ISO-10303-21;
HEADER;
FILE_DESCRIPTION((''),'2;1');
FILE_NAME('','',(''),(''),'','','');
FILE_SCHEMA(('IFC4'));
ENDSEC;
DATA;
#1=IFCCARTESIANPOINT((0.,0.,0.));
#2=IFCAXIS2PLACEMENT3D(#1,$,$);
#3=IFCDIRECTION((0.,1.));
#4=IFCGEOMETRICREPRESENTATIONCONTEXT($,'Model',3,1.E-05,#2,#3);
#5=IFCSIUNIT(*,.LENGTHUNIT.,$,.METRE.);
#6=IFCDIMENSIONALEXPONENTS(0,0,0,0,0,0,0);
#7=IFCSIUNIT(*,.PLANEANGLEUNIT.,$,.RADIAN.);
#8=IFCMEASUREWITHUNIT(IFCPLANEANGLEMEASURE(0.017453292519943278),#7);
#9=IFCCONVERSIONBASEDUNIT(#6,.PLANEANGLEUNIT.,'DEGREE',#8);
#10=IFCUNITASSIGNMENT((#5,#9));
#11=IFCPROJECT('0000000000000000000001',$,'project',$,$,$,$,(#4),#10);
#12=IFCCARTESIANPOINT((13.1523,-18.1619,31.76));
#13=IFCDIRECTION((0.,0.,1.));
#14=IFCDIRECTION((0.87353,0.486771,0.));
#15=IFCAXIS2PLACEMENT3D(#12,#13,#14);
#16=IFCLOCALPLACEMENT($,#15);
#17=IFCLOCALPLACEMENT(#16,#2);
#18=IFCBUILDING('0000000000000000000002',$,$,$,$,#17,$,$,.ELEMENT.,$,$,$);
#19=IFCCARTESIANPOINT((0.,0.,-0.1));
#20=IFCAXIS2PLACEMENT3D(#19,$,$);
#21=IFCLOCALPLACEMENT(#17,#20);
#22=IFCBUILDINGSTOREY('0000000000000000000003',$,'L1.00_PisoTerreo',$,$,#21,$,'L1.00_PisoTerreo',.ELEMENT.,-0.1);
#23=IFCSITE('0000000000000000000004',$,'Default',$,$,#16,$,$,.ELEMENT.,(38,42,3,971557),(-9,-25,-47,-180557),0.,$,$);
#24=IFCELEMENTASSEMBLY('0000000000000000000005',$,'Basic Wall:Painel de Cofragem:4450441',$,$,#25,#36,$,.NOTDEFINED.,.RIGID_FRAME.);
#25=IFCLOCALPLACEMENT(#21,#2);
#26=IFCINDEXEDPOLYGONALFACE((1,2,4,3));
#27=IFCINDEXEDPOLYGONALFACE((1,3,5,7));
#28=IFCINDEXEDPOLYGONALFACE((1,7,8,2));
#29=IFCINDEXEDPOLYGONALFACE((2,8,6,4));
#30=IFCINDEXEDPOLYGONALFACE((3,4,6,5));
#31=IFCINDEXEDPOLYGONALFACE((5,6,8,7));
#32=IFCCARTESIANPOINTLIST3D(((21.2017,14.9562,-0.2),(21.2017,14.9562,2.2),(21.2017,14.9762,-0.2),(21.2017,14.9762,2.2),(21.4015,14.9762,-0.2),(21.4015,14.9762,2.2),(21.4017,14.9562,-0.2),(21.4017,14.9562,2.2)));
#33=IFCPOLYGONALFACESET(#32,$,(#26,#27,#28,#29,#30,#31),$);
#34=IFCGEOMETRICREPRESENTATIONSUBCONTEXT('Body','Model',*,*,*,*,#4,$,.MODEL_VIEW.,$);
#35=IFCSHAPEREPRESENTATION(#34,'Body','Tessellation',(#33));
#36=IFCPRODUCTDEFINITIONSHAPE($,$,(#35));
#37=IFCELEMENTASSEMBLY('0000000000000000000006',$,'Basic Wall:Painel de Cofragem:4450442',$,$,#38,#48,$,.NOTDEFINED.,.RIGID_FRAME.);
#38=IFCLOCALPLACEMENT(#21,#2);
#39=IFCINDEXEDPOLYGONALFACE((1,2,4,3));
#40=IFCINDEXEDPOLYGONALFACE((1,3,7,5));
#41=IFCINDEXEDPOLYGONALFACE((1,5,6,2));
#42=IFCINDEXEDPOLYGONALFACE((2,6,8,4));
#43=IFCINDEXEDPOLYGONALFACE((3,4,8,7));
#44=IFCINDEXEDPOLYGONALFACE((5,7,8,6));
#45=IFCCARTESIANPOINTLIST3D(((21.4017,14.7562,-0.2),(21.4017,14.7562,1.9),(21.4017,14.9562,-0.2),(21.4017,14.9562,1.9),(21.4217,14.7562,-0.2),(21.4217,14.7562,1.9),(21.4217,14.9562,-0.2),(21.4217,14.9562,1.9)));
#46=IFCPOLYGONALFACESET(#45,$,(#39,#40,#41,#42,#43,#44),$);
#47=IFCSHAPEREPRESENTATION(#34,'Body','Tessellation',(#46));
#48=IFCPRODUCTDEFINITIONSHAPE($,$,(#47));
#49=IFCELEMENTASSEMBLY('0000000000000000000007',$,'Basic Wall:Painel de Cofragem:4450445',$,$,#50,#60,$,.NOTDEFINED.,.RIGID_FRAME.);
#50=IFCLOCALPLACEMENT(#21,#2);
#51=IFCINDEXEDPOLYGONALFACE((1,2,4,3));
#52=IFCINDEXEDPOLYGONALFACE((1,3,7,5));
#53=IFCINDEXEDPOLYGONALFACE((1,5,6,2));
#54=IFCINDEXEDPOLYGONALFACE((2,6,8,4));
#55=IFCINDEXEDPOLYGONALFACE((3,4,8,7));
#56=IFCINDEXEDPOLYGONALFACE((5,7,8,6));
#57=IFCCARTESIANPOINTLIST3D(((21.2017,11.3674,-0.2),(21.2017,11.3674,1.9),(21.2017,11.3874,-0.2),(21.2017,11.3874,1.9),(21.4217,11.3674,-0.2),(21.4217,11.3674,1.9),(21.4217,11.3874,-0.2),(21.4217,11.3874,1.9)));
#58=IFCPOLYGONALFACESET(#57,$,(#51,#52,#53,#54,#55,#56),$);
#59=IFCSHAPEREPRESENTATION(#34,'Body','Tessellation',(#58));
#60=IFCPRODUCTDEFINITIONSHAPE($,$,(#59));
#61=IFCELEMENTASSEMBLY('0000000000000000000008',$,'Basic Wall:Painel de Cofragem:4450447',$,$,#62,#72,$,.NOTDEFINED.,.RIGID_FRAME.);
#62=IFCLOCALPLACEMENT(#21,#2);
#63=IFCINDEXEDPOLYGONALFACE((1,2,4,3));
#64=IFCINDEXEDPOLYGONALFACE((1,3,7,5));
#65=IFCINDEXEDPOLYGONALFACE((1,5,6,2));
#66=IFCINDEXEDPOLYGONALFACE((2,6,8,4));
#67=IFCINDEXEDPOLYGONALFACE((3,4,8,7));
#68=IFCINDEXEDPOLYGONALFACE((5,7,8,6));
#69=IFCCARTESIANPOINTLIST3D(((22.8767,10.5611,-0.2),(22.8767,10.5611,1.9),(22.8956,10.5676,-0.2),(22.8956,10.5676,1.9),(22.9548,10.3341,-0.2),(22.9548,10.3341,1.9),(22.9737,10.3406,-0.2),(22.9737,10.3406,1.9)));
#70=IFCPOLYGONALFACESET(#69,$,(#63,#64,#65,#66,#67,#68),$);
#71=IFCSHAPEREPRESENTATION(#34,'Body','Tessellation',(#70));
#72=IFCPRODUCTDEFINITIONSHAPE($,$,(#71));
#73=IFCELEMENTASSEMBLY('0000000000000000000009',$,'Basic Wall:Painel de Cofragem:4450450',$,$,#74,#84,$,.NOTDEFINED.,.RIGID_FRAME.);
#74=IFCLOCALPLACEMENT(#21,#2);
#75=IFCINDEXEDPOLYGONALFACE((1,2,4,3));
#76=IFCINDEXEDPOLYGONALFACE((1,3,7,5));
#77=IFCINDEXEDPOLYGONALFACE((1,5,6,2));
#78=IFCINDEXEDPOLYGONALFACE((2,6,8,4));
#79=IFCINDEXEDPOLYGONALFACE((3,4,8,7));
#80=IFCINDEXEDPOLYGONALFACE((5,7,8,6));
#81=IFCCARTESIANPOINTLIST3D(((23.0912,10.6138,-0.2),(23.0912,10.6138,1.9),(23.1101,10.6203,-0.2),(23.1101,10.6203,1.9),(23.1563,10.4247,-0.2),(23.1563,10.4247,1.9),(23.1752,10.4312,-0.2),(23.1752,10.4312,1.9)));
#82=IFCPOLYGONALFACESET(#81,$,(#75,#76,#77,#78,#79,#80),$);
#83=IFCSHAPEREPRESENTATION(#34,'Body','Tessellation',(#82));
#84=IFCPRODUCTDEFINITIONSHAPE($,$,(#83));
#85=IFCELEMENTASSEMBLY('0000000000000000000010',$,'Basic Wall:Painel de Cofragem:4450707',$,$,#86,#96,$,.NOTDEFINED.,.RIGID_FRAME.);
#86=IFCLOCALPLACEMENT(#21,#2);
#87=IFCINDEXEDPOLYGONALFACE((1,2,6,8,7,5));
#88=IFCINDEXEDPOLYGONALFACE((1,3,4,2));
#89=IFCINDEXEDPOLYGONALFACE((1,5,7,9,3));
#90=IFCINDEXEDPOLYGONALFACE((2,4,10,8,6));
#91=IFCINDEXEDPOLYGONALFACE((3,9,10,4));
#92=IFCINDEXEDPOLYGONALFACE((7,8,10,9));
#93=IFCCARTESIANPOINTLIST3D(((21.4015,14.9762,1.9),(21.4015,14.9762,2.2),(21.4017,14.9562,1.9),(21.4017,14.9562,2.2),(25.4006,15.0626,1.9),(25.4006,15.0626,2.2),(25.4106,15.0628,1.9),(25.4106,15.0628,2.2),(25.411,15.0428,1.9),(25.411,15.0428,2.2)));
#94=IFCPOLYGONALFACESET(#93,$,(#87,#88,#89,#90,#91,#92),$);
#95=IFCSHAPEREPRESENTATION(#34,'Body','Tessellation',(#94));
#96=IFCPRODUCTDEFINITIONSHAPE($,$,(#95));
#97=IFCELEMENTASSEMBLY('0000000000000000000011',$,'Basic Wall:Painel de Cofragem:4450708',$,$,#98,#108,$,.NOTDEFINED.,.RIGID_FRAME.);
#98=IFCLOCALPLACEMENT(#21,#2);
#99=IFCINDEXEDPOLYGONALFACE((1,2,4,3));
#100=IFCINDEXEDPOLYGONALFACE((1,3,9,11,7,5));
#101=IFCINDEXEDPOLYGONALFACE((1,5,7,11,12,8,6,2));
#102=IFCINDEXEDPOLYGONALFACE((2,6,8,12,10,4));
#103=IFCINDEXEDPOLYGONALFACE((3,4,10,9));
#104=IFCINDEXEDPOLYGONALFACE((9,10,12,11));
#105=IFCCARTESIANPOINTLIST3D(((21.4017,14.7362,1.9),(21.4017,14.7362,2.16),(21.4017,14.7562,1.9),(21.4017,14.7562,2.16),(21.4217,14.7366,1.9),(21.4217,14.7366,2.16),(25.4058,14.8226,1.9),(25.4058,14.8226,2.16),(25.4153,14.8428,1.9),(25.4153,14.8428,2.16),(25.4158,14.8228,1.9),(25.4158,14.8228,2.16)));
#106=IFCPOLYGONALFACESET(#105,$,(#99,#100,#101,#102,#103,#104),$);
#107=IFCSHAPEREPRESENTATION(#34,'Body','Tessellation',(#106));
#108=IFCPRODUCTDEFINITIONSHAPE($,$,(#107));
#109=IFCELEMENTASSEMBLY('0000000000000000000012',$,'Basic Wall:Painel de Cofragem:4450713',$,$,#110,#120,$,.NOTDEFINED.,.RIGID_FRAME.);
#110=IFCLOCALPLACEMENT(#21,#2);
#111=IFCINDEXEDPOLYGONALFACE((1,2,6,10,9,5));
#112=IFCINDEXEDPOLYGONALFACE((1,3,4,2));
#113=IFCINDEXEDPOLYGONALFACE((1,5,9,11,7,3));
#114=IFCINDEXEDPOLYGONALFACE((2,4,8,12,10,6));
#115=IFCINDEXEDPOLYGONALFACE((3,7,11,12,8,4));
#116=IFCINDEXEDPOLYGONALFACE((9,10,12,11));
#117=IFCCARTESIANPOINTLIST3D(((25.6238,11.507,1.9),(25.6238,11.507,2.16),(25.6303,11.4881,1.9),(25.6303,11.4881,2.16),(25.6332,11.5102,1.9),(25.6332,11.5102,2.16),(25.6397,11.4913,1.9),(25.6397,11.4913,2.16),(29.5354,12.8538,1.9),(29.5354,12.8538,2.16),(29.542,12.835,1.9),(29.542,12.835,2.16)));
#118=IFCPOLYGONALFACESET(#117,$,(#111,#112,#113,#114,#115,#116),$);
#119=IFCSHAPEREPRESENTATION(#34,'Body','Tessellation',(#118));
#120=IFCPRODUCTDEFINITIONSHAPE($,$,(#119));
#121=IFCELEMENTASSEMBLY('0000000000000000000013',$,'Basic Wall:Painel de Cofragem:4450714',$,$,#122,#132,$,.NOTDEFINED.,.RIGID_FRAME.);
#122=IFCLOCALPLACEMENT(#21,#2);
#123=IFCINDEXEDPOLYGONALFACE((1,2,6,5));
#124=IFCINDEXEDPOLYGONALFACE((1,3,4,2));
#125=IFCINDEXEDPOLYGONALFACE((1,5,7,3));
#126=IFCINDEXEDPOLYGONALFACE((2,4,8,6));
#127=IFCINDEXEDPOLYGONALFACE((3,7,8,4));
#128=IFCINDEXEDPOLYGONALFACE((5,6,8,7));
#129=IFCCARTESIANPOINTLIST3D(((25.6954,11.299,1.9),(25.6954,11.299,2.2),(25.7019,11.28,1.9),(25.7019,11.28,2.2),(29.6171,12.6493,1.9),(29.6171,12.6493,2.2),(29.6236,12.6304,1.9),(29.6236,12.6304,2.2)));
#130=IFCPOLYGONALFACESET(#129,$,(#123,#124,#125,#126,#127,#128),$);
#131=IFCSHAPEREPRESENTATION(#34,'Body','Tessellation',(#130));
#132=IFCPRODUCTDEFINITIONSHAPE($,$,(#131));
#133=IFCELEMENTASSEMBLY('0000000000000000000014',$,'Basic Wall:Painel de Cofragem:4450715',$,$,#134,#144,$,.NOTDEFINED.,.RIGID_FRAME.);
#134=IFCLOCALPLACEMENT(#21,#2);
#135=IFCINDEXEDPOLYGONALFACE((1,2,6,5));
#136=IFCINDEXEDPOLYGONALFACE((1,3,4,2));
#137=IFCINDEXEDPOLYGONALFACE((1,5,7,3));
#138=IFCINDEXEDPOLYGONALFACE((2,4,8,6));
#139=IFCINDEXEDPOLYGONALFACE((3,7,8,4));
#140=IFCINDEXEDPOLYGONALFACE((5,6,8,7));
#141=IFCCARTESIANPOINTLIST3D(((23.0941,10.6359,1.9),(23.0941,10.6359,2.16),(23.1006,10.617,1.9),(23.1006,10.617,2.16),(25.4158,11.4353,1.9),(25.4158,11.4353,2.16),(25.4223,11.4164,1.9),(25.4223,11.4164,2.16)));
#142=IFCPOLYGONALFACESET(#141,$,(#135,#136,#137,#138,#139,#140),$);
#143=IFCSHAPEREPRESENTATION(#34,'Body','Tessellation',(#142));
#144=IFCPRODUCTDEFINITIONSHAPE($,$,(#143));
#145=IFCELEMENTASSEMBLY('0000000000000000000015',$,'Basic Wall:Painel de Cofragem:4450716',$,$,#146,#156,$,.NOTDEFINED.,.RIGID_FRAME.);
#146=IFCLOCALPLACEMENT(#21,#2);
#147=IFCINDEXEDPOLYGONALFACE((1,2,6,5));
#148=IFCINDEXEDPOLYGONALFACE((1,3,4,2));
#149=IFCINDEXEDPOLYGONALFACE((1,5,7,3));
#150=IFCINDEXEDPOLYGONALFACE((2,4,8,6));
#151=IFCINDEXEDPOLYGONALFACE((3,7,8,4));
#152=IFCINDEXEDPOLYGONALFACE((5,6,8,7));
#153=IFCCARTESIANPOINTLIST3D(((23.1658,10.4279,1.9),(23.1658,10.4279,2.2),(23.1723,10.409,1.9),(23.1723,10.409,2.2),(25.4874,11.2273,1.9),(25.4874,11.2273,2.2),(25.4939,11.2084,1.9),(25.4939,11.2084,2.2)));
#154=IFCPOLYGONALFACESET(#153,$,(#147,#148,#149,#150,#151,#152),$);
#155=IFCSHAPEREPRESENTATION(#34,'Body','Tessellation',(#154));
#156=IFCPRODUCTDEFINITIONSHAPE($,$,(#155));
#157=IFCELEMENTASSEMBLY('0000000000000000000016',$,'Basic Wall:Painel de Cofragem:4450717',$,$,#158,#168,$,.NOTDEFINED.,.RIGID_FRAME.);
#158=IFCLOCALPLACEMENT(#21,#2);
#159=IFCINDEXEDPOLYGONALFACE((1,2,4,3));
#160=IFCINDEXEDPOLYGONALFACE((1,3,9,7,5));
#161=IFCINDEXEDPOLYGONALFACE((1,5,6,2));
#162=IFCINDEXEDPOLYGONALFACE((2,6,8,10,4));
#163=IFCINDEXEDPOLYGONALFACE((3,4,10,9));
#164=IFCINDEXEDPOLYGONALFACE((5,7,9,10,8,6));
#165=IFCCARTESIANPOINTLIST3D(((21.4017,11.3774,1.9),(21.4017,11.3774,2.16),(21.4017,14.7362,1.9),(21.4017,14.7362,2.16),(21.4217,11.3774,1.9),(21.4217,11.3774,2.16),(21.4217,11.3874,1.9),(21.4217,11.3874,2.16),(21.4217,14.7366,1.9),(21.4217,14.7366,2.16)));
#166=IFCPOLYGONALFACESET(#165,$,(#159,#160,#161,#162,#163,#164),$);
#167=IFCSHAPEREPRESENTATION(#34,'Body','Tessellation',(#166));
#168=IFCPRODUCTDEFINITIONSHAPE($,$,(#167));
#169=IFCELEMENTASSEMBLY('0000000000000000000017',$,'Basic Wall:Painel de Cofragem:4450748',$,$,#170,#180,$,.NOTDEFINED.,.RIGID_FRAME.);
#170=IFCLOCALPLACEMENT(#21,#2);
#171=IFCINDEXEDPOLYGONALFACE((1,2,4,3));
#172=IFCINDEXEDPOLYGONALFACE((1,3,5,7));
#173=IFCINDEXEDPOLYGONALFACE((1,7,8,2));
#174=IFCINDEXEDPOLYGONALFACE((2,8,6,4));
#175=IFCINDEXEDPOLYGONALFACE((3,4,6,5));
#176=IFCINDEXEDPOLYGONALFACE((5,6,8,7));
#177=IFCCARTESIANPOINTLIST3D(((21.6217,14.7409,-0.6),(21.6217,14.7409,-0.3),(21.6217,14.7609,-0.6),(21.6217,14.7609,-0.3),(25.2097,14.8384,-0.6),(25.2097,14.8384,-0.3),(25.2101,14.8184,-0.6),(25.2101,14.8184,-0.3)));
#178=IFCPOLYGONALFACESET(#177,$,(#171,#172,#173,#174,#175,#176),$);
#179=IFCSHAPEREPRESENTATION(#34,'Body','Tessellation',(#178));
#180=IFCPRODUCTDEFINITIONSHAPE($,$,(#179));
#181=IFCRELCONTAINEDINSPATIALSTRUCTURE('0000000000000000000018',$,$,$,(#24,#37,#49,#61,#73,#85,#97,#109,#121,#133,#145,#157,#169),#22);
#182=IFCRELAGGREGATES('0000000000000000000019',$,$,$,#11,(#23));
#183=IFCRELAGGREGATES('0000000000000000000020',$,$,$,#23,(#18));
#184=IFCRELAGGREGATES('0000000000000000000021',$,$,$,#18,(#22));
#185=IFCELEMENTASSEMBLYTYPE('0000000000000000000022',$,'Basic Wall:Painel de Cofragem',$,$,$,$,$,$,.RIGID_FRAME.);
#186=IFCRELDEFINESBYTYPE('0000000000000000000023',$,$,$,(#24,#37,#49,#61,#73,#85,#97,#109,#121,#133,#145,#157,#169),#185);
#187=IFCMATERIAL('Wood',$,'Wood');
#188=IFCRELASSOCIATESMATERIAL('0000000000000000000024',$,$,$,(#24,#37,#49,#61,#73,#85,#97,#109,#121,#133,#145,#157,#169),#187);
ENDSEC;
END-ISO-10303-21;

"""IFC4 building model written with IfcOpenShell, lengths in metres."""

from ifc_helpers import new_model, entity, si_unit, converted_unit, direction, frame, origin, place, context, subcontext, project, spatial, indexed_curve, outline, extrude, material, type_object, element, save


model = new_model("IFC4")

# Units and contexts
model_context = context("Model", 3, precision=1e-05, world=origin(), true_north=direction((0.0, 1.0)))
body_context = subcontext(model_context, "Body", "Model", "MODEL_VIEW")
ifc_project = project(units=[si_unit("LENGTHUNIT", "METRE"), converted_unit("PLANEANGLEUNIT", "DEGREE", entity("IfcPlaneAngleMeasure", 0.017453292519943278), si_unit("PLANEANGLEUNIT", "RADIAN"), dimensions=[0, 0, 0, 0, 0, 0, 0])], contexts=[model_context])

# Site, building, storey
site_placement = place(None, frame((13.1523, -18.1619, 31.76), z_axis=(0.0, 0.0, 1.0), x_axis=(0.87353, 0.486771, 0.0)))
site = spatial("IfcSite", under=ifc_project, at=site_placement, Name="Default", CompositionType="ELEMENT", RefLatitude=(38, 42, 3, 971557), RefLongitude=(-9, -25, -47, -180557), RefElevation=0.0)
building_placement = place(site_placement, origin())
building = spatial("IfcBuilding", under=site, at=building_placement, CompositionType="ELEMENT")
storey_placement = place(building_placement, frame((0.0, 0.0, -0.1)))
storey = spatial("IfcBuildingStorey", under=building, at=storey_placement, Name="L1.00_PisoTerreo", LongName="L1.00_PisoTerreo", CompositionType="ELEMENT", Elevation=-0.1)

# Element assemblies
ifc_material_1 = material(Name="Wood", Category="Wood")
element_assembly_type = type_object("IfcElementAssemblyType", Name="Basic Wall:Painel de Cofragem", PredefinedType="RIGID_FRAME")
assembly_1_placement = place(storey_placement, frame((21.4017, 14.9662, -0.2), z_axis=(0.0, 0.0, 1.0), x_axis=(-1.0, 0.0, 0.0)))
element("IfcElementAssembly", 1, at=assembly_1_placement, inside=storey, type_object=element_assembly_type, material=ifc_material_1, Name="Basic Wall:Painel de Cofragem:4450441", AssemblyPlace="NOTDEFINED", PredefinedType="RIGID_FRAME", context=body_context, shape_type="SweptSolid", body=[
    extrude(outline(indexed_curve([(0.2, -0.01), (0.2, 0.01), (0.0, 0.01), (0.0002, -0.01), (0.2, -0.01)], self_intersect=False)), origin(), (0.0, 0.0, 1.0), 2.4),
])
assembly_2_placement = place(storey_placement, frame((21.4117, 14.9562, -0.2), z_axis=(0.0, 0.0, 1.0), x_axis=(0.0, -1.0, 0.0)))
element("IfcElementAssembly", 2, at=assembly_2_placement, inside=storey, type_object=element_assembly_type, material=ifc_material_1, Name="Basic Wall:Painel de Cofragem:4450442", AssemblyPlace="NOTDEFINED", PredefinedType="RIGID_FRAME", context=body_context, shape_type="SweptSolid", body=[
    extrude(outline(indexed_curve([(0.2, 0.01), (0.0, 0.01), (0.0, -0.01), (0.2, -0.01), (0.2, 0.01)], self_intersect=False)), origin(), (0.0, 0.0, 1.0), 2.1),
])
assembly_3_placement = place(storey_placement, frame((21.4217, 11.3774, -0.2), z_axis=(0.0, 0.0, 1.0), x_axis=(-1.0, 0.0, 0.0)))
element("IfcElementAssembly", 3, at=assembly_3_placement, inside=storey, type_object=element_assembly_type, material=ifc_material_1, Name="Basic Wall:Painel de Cofragem:4450445", AssemblyPlace="NOTDEFINED", PredefinedType="RIGID_FRAME", context=body_context, shape_type="SweptSolid", body=[
    extrude(outline(indexed_curve([(0.22, 0.01), (0.0, 0.01), (0.0, -0.01), (0.22, -0.01), (0.22, 0.01)], self_intersect=False)), origin(), (0.0, 0.0, 1.0), 2.1),
])
assembly_4_placement = place(storey_placement, frame((22.8861, 10.5643, -0.2), z_axis=(0.0, 0.0, 1.0), x_axis=(0.325568, -0.945519, 0.0)))
element("IfcElementAssembly", 4, at=assembly_4_placement, inside=storey, type_object=element_assembly_type, material=ifc_material_1, Name="Basic Wall:Painel de Cofragem:4450447", AssemblyPlace="NOTDEFINED", PredefinedType="RIGID_FRAME", context=body_context, shape_type="SweptSolid", body=[
    extrude(outline(indexed_curve([(0.24, 0.01), (0.0, 0.01), (0.0, -0.01), (0.24, -0.01), (0.24, 0.01)], self_intersect=False)), origin(), (0.0, 0.0, 1.0), 2.1),
])
assembly_5_placement = place(storey_placement, frame((23.1006, 10.617, -0.2), z_axis=(0.0, 0.0, 1.0), x_axis=(0.325568, -0.945519, 0.0)))
element("IfcElementAssembly", 5, at=assembly_5_placement, inside=storey, type_object=element_assembly_type, material=ifc_material_1, Name="Basic Wall:Painel de Cofragem:4450450", AssemblyPlace="NOTDEFINED", PredefinedType="RIGID_FRAME", context=body_context, shape_type="SweptSolid", body=[
    extrude(outline(indexed_curve([(0.2, 0.01), (0.0, 0.01), (0.0, -0.01), (0.2, -0.01), (0.2, 0.01)], self_intersect=False)), origin(), (0.0, 0.0, 1.0), 2.1),
])
assembly_6_placement = place(storey_placement, frame((21.4015, 14.9662, 1.9), z_axis=(0.0, 0.0, 1.0), x_axis=(0.999767, 0.021581, 0.0)))
element("IfcElementAssembly", 6, at=assembly_6_placement, inside=storey, type_object=element_assembly_type, material=ifc_material_1, Name="Basic Wall:Painel de Cofragem:4450707", AssemblyPlace="NOTDEFINED", PredefinedType="RIGID_FRAME", context=body_context, shape_type="SweptSolid", body=[
    extrude(outline(indexed_curve([(4.0103, -0.01), (4.0103, 0.01), (4.0003, 0.01), (0.0002, 0.01), (0.0, -0.01), (4.0103, -0.01)], self_intersect=False)), origin(), (0.0, 0.0, 1.0), 0.3),
])
assembly_7_placement = place(storey_placement, frame((21.4015, 14.7462, 1.9), z_axis=(0.0, 0.0, 1.0), x_axis=(0.999767, 0.021581, 0.0)))
element("IfcElementAssembly", 7, at=assembly_7_placement, inside=storey, type_object=element_assembly_type, material=ifc_material_1, Name="Basic Wall:Painel de Cofragem:4450708", AssemblyPlace="NOTDEFINED", PredefinedType="RIGID_FRAME", context=body_context, shape_type="SweptSolid", body=[
    extrude(outline(indexed_curve([(4.015, -0.01), (4.015, 0.01), (0.0004, 0.01), (0.0, -0.01), (0.02, -0.01), (4.005, -0.01), (4.015, -0.01)], self_intersect=False)), origin(), (0.0, 0.0, 1.0), 0.26),
])
assembly_8_placement = place(storey_placement, frame((25.627, 11.4975, 1.9), z_axis=(0.0, 0.0, 1.0), x_axis=(0.945519, 0.325568, 0.0)))
element("IfcElementAssembly", 8, at=assembly_8_placement, inside=storey, type_object=element_assembly_type, material=ifc_material_1, Name="Basic Wall:Painel de Cofragem:4450713", AssemblyPlace="NOTDEFINED", PredefinedType="RIGID_FRAME", context=body_context, shape_type="SweptSolid", body=[
    extrude(outline(indexed_curve([(4.1371, -0.01), (4.137, 0.01), (0.01, 0.01), (0.0, 0.01), (0.0, -0.01), (0.01, -0.01), (4.1371, -0.01)], self_intersect=False)), origin(), (0.0, 0.0, 1.0), 0.26),
])
assembly_9_placement = place(storey_placement, frame((25.6987, 11.2895, 1.9), z_axis=(0.0, 0.0, 1.0), x_axis=(0.945519, 0.325568, 0.0)))
element("IfcElementAssembly", 9, at=assembly_9_placement, inside=storey, type_object=element_assembly_type, material=ifc_material_1, Name="Basic Wall:Painel de Cofragem:4450714", AssemblyPlace="NOTDEFINED", PredefinedType="RIGID_FRAME", context=body_context, shape_type="SweptSolid", body=[
    extrude(outline(indexed_curve([(4.1477, 0.01), (0.0, 0.01), (0.0, -0.01), (4.1477, -0.01), (4.1477, 0.01)], self_intersect=False)), origin(), (0.0, 0.0, 1.0), 0.3),
])
assembly_10_placement = place(storey_placement, frame((23.0974, 10.6265, 1.9), z_axis=(0.0, 0.0, 1.0), x_axis=(0.945519, 0.325568, 0.0)))
element("IfcElementAssembly", 10, at=assembly_10_placement, inside=storey, type_object=element_assembly_type, material=ifc_material_1, Name="Basic Wall:Painel de Cofragem:4450715", AssemblyPlace="NOTDEFINED", PredefinedType="RIGID_FRAME", context=body_context, shape_type="SweptSolid", body=[
    extrude(outline(indexed_curve([(2.4554, 0.01), (0.0, 0.01), (0.0, -0.01), (2.4554, -0.01), (2.4554, 0.01)], self_intersect=False)), origin(), (0.0, 0.0, 1.0), 0.26),
])
assembly_11_placement = place(storey_placement, frame((23.169, 10.4185, 1.9), z_axis=(0.0, 0.0, 1.0), x_axis=(0.945519, 0.325568, 0.0)))
element("IfcElementAssembly", 11, at=assembly_11_placement, inside=storey, type_object=element_assembly_type, material=ifc_material_1, Name="Basic Wall:Painel de Cofragem:4450716", AssemblyPlace="NOTDEFINED", PredefinedType="RIGID_FRAME", context=body_context, shape_type="SweptSolid", body=[
    extrude(outline(indexed_curve([(2.4554, 0.01), (0.0, 0.01), (0.0, -0.01), (2.4554, -0.01), (2.4554, 0.01)], self_intersect=False)), origin(), (0.0, 0.0, 1.0), 0.3),
])
assembly_12_placement = place(storey_placement, frame((21.4117, 11.3774, 1.9), z_axis=(0.0, 0.0, 1.0), x_axis=(0.0, 1.0, 0.0)))
element("IfcElementAssembly", 12, at=assembly_12_placement, inside=storey, type_object=element_assembly_type, material=ifc_material_1, Name="Basic Wall:Painel de Cofragem:4450717", AssemblyPlace="NOTDEFINED", PredefinedType="RIGID_FRAME", context=body_context, shape_type="SweptSolid", body=[
    extrude(outline(indexed_curve([(3.3592, -0.01), (3.3587, 0.01), (0.0, 0.01), (0.0, -0.01), (0.01, -0.01), (3.3592, -0.01)], self_intersect=False)), origin(), (0.0, 0.0, 1.0), 0.26),
])
assembly_13_placement = place(storey_placement, frame((21.6215, 14.7509, -0.6), z_axis=(0.0, 0.0, 1.0), x_axis=(0.999767, 0.021581, 0.0)))
element("IfcElementAssembly", 13, at=assembly_13_placement, inside=storey, type_object=element_assembly_type, material=ifc_material_1, Name="Basic Wall:Painel de Cofragem:4450748", AssemblyPlace="NOTDEFINED", PredefinedType="RIGID_FRAME", context=body_context, shape_type="SweptSolid", body=[
    extrude(outline(indexed_curve([(3.5893, -0.01), (3.5893, 0.01), (0.0004, 0.01), (0.0, -0.01), (3.5893, -0.01)], self_intersect=False)), origin(), (0.0, 0.0, 1.0), 0.3),
])

save(model, "model.ifc")
